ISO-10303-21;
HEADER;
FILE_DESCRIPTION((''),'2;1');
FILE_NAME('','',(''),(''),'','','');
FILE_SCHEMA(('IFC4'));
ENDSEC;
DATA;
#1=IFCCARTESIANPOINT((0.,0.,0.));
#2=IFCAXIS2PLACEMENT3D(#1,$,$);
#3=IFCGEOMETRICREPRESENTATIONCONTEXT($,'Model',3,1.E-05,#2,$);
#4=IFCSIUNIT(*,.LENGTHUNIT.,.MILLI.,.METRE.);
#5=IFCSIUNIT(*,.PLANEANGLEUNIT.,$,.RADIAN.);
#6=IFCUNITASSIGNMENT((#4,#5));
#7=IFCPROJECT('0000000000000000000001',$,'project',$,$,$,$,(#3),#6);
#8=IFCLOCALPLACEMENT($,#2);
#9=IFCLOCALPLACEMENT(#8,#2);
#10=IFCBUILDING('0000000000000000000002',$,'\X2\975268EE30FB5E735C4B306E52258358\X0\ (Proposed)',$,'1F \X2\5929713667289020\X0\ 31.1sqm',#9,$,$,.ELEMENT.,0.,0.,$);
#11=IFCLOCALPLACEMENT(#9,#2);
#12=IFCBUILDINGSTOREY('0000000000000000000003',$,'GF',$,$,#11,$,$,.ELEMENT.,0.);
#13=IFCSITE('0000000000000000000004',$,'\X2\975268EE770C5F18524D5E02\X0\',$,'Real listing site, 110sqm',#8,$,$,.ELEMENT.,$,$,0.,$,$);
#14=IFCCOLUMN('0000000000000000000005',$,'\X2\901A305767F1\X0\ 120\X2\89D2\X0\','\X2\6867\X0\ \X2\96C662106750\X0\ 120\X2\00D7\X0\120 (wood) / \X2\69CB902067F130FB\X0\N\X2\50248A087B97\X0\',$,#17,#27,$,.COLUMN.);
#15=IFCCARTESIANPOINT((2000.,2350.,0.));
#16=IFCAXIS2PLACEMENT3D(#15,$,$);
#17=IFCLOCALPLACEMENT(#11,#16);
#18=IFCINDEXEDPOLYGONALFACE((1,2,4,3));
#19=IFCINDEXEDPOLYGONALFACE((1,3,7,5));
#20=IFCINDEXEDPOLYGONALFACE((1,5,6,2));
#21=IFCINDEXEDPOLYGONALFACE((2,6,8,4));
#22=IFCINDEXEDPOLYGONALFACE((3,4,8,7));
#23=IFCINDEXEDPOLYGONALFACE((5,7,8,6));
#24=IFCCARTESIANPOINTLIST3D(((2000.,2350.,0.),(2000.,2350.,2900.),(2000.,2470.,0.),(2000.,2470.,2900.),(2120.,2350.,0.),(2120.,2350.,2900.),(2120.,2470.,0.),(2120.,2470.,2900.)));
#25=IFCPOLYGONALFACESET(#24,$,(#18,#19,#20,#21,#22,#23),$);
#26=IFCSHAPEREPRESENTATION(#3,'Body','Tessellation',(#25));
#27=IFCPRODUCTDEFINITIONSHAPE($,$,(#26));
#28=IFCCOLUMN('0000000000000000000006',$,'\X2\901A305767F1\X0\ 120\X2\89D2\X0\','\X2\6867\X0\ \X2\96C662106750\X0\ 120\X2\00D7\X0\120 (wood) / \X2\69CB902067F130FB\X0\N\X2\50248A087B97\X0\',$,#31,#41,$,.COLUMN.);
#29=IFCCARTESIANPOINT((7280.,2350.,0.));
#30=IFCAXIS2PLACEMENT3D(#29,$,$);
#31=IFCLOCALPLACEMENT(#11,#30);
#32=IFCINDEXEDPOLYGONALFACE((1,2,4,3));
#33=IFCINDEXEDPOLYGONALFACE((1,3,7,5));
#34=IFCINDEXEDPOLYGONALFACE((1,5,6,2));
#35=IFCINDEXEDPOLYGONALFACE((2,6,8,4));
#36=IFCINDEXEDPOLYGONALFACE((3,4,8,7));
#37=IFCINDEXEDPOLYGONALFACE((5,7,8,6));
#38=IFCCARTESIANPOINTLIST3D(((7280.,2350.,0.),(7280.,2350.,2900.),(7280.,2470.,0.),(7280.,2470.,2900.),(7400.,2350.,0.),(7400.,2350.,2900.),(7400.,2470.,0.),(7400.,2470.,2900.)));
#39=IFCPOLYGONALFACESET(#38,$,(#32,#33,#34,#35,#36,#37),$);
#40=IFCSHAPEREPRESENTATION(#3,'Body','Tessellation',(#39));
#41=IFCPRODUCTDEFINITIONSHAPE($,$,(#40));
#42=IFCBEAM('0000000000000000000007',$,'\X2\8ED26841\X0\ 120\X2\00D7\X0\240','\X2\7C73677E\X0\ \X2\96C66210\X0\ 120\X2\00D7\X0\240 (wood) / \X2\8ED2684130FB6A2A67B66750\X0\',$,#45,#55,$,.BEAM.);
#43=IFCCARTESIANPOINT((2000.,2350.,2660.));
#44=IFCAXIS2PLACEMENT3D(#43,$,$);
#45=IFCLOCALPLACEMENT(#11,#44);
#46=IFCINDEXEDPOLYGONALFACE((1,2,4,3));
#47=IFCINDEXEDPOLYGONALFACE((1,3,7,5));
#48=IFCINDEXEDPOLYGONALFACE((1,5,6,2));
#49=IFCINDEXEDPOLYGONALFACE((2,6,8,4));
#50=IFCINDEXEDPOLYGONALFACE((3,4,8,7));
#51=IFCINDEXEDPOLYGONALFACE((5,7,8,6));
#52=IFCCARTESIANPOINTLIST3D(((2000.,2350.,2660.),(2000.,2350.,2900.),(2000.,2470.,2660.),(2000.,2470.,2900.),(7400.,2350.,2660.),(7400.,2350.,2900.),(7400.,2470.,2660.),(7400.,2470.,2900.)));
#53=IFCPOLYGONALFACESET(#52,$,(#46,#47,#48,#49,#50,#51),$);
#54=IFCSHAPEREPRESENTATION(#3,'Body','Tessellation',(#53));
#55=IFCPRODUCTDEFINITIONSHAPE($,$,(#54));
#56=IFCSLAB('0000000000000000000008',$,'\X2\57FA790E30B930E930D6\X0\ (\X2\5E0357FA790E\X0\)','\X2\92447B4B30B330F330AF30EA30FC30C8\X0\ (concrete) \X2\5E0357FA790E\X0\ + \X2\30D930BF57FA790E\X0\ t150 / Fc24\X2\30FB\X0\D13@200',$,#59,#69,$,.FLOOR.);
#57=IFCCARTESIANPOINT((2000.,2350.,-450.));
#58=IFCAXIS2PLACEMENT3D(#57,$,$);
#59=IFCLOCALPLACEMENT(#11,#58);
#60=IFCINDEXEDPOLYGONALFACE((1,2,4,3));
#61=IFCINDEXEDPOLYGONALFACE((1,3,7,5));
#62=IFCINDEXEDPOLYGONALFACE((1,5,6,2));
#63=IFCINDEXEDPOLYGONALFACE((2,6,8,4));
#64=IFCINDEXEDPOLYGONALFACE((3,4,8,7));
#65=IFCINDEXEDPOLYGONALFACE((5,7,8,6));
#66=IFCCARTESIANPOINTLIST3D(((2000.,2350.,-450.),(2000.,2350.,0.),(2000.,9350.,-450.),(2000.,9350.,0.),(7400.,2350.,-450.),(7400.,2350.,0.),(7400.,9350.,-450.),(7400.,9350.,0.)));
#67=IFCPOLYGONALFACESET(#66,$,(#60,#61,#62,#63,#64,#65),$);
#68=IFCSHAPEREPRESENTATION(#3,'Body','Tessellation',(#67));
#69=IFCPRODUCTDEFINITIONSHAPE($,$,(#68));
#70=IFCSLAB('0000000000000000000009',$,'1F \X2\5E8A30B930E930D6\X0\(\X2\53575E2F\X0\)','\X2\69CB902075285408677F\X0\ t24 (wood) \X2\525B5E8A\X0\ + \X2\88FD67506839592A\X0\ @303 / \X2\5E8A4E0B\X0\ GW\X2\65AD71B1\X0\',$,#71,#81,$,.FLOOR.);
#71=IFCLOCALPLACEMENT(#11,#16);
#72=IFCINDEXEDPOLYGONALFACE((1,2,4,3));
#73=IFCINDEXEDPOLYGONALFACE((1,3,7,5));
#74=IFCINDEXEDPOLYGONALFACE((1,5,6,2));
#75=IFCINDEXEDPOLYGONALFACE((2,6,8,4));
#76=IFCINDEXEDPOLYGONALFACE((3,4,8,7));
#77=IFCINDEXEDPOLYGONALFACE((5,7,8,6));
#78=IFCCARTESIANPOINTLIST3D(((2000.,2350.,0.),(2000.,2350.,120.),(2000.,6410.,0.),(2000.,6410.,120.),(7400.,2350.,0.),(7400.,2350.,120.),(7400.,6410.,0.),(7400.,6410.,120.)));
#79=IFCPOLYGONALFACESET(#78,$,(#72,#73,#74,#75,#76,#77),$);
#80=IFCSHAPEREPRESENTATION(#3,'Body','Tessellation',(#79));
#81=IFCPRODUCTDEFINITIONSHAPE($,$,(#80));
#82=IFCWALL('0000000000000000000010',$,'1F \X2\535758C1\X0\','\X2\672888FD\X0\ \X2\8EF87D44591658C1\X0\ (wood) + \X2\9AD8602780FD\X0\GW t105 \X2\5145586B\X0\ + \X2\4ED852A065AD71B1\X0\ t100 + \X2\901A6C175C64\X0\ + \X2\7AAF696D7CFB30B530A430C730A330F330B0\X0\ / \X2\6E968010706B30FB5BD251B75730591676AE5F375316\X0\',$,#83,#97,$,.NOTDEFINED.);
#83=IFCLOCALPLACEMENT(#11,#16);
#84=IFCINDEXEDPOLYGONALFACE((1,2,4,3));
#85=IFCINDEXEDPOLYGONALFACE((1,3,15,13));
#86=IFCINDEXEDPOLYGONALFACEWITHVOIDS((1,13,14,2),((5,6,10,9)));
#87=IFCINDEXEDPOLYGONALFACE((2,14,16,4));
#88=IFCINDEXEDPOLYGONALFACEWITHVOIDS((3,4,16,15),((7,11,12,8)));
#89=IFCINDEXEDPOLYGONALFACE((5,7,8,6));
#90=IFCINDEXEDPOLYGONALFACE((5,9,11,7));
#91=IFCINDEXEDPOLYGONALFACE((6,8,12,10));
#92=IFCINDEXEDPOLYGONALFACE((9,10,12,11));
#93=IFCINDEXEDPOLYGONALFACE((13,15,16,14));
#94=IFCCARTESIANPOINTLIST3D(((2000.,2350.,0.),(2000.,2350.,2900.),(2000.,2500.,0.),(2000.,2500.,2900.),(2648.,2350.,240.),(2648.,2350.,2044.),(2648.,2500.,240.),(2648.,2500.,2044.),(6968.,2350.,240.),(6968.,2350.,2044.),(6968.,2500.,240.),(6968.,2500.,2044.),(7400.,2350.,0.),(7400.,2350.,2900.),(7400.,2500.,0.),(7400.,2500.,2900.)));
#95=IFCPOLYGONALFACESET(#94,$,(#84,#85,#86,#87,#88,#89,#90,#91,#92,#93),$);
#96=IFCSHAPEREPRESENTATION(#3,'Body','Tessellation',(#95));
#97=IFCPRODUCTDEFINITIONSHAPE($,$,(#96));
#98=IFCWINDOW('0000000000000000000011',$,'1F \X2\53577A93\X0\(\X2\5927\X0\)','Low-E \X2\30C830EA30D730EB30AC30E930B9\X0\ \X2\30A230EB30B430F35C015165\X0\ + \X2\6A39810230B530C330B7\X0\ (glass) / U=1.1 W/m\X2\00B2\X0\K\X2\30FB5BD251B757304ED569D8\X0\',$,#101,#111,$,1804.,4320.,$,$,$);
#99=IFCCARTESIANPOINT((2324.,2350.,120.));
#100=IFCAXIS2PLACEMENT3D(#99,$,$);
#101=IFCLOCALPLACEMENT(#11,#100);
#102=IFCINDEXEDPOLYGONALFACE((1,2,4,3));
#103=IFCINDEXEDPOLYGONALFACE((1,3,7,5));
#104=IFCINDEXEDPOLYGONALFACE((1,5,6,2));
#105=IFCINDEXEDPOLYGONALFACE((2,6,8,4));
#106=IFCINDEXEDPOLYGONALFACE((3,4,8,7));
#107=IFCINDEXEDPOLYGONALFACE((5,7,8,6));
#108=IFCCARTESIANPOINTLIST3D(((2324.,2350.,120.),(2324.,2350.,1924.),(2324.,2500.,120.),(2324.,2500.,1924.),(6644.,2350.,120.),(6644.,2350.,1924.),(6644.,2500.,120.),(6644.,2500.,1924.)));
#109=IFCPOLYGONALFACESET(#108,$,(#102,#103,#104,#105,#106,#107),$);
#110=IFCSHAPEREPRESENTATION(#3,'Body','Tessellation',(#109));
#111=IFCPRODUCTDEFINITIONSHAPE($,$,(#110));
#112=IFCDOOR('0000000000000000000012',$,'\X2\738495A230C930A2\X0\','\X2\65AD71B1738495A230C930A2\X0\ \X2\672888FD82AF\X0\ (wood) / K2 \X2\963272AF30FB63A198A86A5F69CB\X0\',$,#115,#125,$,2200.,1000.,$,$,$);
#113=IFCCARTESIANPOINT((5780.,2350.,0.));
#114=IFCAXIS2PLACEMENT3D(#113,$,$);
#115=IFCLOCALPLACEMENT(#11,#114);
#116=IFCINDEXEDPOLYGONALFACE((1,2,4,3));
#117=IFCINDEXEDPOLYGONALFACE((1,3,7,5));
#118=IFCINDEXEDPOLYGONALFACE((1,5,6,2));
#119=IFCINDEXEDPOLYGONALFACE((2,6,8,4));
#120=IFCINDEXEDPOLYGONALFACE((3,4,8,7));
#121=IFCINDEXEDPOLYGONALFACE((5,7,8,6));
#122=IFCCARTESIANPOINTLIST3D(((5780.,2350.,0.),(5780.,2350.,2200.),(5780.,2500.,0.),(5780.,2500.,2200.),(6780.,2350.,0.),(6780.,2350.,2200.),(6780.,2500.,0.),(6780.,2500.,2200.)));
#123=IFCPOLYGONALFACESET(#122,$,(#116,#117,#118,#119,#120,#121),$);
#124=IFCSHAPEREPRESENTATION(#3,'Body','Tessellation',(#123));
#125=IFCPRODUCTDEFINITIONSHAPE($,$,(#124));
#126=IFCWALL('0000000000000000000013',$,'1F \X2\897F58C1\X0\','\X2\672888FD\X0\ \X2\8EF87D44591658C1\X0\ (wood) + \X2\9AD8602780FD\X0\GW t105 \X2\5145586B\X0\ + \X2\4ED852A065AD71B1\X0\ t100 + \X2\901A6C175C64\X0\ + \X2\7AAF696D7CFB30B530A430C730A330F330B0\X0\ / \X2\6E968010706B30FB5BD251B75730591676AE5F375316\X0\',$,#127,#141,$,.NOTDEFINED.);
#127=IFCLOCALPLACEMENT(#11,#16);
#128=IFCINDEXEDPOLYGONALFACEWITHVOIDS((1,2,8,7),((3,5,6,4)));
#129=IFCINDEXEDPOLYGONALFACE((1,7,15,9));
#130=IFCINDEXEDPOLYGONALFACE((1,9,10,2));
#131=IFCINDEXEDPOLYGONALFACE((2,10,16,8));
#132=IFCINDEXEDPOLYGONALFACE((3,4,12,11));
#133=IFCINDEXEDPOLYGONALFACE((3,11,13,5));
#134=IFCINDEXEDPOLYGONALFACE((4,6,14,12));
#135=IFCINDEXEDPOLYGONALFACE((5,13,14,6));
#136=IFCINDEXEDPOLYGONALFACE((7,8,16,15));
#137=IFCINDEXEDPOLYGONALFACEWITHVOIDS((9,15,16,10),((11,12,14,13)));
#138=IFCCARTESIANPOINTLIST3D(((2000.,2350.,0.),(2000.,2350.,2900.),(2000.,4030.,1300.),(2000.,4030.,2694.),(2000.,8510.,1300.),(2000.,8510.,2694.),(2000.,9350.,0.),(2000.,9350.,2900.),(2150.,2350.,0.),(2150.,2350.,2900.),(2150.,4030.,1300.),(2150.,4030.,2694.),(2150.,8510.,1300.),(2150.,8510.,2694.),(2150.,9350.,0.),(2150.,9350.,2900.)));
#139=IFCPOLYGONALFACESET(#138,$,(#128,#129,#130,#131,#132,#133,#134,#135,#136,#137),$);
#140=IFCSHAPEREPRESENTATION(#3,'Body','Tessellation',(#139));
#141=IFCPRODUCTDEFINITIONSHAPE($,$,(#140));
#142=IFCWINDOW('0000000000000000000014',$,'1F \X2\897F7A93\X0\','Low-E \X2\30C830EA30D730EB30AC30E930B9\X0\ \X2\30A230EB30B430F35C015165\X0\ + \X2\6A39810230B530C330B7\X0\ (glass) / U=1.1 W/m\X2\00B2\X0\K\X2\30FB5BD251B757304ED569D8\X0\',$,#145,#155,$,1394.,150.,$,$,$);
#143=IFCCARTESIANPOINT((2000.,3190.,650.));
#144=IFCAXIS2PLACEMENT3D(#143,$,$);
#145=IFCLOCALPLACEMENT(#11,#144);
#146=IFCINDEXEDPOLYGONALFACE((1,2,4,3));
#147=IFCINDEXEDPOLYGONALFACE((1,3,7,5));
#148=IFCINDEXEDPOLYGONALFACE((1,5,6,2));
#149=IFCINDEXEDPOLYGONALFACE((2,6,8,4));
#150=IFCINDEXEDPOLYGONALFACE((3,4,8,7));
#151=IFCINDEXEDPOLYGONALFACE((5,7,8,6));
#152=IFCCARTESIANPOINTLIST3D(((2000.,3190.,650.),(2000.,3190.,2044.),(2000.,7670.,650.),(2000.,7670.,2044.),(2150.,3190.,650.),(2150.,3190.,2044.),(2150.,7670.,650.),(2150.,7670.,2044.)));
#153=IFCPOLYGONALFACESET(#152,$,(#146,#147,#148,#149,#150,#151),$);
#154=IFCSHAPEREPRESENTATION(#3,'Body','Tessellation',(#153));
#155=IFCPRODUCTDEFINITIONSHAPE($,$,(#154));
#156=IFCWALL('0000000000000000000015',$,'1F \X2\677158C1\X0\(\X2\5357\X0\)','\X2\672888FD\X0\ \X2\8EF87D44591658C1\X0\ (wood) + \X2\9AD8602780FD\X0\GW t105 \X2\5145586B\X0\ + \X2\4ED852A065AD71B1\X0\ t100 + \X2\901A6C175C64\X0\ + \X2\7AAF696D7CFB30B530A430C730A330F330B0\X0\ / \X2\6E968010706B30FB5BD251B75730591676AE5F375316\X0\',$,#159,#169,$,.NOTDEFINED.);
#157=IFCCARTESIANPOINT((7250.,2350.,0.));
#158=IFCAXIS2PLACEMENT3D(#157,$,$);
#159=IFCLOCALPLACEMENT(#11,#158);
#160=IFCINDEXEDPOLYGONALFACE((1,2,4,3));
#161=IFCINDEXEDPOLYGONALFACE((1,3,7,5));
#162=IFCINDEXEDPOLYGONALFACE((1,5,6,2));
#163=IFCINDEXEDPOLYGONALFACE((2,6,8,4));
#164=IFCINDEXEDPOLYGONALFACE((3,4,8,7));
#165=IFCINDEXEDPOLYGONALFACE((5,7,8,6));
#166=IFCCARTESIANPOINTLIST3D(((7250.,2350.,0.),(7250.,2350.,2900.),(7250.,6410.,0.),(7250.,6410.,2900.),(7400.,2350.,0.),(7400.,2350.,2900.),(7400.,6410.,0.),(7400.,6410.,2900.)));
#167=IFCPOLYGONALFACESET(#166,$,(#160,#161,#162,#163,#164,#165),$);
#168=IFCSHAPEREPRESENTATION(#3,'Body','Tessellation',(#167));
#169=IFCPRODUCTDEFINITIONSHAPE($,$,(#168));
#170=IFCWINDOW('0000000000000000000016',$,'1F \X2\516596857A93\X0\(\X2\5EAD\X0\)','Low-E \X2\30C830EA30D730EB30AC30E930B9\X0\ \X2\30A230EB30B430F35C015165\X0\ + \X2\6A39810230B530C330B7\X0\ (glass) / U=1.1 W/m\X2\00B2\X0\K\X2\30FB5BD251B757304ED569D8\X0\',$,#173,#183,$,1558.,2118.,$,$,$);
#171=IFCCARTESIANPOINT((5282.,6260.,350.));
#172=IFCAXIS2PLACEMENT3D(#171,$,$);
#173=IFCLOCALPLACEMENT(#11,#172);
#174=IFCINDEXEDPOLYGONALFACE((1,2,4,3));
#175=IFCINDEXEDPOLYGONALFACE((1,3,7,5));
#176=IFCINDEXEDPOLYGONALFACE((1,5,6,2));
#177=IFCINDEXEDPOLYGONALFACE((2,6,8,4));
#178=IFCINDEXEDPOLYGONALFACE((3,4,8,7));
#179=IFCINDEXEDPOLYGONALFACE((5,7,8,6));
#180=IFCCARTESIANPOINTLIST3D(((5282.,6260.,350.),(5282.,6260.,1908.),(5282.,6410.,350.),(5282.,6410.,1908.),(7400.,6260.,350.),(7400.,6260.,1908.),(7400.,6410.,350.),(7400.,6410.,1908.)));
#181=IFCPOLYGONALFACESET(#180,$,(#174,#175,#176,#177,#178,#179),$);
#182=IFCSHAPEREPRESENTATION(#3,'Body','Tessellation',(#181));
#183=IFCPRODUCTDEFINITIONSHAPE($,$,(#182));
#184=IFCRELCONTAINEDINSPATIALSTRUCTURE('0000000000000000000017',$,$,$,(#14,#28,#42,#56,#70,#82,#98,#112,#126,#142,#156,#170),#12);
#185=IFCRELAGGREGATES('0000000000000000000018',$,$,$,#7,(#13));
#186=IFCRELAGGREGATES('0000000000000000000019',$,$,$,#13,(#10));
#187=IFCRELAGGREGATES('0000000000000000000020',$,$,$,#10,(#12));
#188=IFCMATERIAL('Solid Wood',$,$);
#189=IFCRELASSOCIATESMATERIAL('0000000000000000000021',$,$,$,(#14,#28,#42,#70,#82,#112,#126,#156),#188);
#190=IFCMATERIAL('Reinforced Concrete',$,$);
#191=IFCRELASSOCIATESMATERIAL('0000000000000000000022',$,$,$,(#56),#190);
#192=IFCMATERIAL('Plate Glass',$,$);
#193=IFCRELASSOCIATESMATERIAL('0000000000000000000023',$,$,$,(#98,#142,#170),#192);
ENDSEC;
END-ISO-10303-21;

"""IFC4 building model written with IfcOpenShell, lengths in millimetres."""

from ifc_helpers import new_model, si_unit, frame, frame_2d, origin, place, context, project, spatial, rectangle, extrude, material, element, fill, save


model = new_model("IFC4")

# Units and contexts
model_context = context("Model", 3, precision=1e-05, world=origin())
ifc_project = project(units=[si_unit("LENGTHUNIT", "METRE", prefix="MILLI"), si_unit("PLANEANGLEUNIT", "RADIAN")], contexts=[model_context])

# Site, building, storey
site_placement = place(None, origin())
site = spatial("IfcSite", under=ifc_project, at=site_placement, Name="青森県弘前市", ObjectType="Real listing site, 110sqm", CompositionType="ELEMENT", RefElevation=0.0)
building_placement = place(site_placement, origin())
building = spatial("IfcBuilding", under=site, at=building_placement, Name="青森・平屋の別荘 (Proposed)", ObjectType="1F 天然木造 31.1sqm", CompositionType="ELEMENT", ElevationOfRefHeight=0.0, ElevationOfTerrain=0.0)
storey_placement = place(building_placement, origin())
storey = spatial("IfcBuildingStorey", under=building, at=storey_placement, Name="GF", CompositionType="ELEMENT", Elevation=0.0)

# Columns
ifc_material_1 = material(Name="Solid Wood")
column_1_placement = place(storey_placement, frame((2000.0, 2350.0, 0.0)))
element("IfcColumn", 1, at=column_1_placement, inside=storey, material=ifc_material_1, Name="通し柱 120角", Description="桧 集成材 120×120 (wood) / 構造柱・N値計算", PredefinedType="COLUMN", context=model_context, shape_type="SweptSolid", body=[
    extrude(rectangle(XDim=120.0, YDim=120.0, at=frame_2d((60.0, 60.0))), frame((2000.0, 2350.0, 0.0)), (0.0, 0.0, 1.0), 2900.0),
])
column_2_placement = place(storey_placement, frame((7280.0, 2350.0, 0.0)))
element("IfcColumn", 2, at=column_2_placement, inside=storey, material=ifc_material_1, Name="通し柱 120角", Description="桧 集成材 120×120 (wood) / 構造柱・N値計算", PredefinedType="COLUMN", context=model_context, shape_type="SweptSolid", body=[
    extrude(rectangle(XDim=120.0, YDim=120.0, at=frame_2d((60.0, 60.0))), frame((7280.0, 2350.0, 0.0)), (0.0, 0.0, 1.0), 2900.0),
])

# Beam
beam_1_placement = place(storey_placement, frame((2000.0, 2350.0, 2660.0)))
element("IfcBeam", 3, at=beam_1_placement, inside=storey, material=ifc_material_1, Name="軒桁 120×240", Description="米松 集成 120×240 (wood) / 軒桁・横架材", PredefinedType="BEAM", context=model_context, shape_type="SweptSolid", body=[
    extrude(rectangle(XDim=5400.0, YDim=120.0, at=frame_2d((2700.0, 60.0))), frame((2000.0, 2350.0, 2660.0)), (0.0, 0.0, 1.0), 240.0),
])

# Slabs
ifc_material_2 = material(Name="Reinforced Concrete")
slab_1_placement = place(storey_placement, frame((2000.0, 2350.0, -450.0)))
element("IfcSlab", 4, at=slab_1_placement, inside=storey, material=ifc_material_2, Name="基礎スラブ (布基礎)", Description="鉄筋コンクリート (concrete) 布基礎 + ベタ基礎 t150 / Fc24・D13@200", PredefinedType="FLOOR", context=model_context, shape_type="SweptSolid", body=[
    extrude(rectangle(XDim=5400.0, YDim=7000.0, at=frame_2d((2700.0, 3500.0))), frame((2000.0, 2350.0, -450.0)), (0.0, 0.0, 1.0), 450.0),
])
slab_2_placement = place(storey_placement, frame((2000.0, 2350.0, 0.0)))
element("IfcSlab", 5, at=slab_2_placement, inside=storey, material=ifc_material_1, Name="1F 床スラブ(南帯)", Description="構造用合板 t24 (wood) 剛床 + 製材根太 @303 / 床下 GW断熱", PredefinedType="FLOOR", context=model_context, shape_type="SweptSolid", body=[
    extrude(rectangle(XDim=5400.0, YDim=4060.0, at=frame_2d((2700.0, 2030.0))), frame((2000.0, 2350.0, 0.0)), (0.0, 0.0, 1.0), 120.0),
])

# Wall, openings, window, door
wall_1_placement = place(storey_placement, frame((2000.0, 2350.0, 0.0)))
wall_1 = element("IfcWall", 6, at=wall_1_placement, inside=storey, material=ifc_material_1, Name="1F 南壁", Description="木製 軸組外壁 (wood) + 高性能GW t105 充填 + 付加断熱 t100 + 通気層 + 窯業系サイディング / 準耐火・寒冷地外皮強化", PredefinedType="NOTDEFINED", context=model_context, shape_type="SweptSolid", body=[
    extrude(rectangle(XDim=5400.0, YDim=150.0, at=frame_2d((2700.0, 75.0))), frame((2000.0, 2350.0, 0.0)), (0.0, 0.0, 1.0), 2900.0),
])
opening_1_placement = place(storey_placement, frame((2324.0, 2350.0, 120.0)))
opening_1 = element("IfcOpeningElement", 7, at=opening_1_placement, cuts=wall_1, PredefinedType="NOTDEFINED", context=model_context, shape_type="SweptSolid", body=[
    extrude(rectangle(XDim=4320.0, YDim=150.0, at=frame_2d((2160.0, 75.0))), frame((2324.0, 2350.0, 120.0)), (0.0, 0.0, 1.0), 1804.0),
])
opening_2_placement = place(storey_placement, frame((5780.0, 2350.0, 0.0)))
opening_2 = element("IfcOpeningElement", 8, at=opening_2_placement, cuts=wall_1, PredefinedType="NOTDEFINED", context=model_context, shape_type="SweptSolid", body=[
    extrude(rectangle(XDim=1000.0, YDim=150.0, at=frame_2d((500.0, 75.0))), frame((5780.0, 2350.0, 0.0)), (0.0, 0.0, 1.0), 2200.0),
])
ifc_material_3 = material(Name="Plate Glass")
window_1_placement = place(storey_placement, frame((2324.0, 2350.0, 120.0)))
window_1 = element("IfcWindow", 9, at=window_1_placement, inside=storey, material=ifc_material_3, Name="1F 南窓(大)", Description="Low-E トリプルガラス アルゴン封入 + 樹脂サッシ (glass) / U=1.1 W/m²K・寒冷地仕様", OverallHeight=1804.0, OverallWidth=4320.0, context=model_context, shape_type="SweptSolid", body=[
    extrude(rectangle(XDim=4320.0, YDim=150.0, at=frame_2d((2160.0, 75.0))), frame((2324.0, 2350.0, 120.0)), (0.0, 0.0, 1.0), 1804.0),
])
fill(opening_1, window_1)
door_1_placement = place(storey_placement, frame((5780.0, 2350.0, 0.0)))
door_1 = element("IfcDoor", 10, at=door_1_placement, inside=storey, material=ifc_material_1, Name="玄関ドア", Description="断熱玄関ドア 木製芯 (wood) / K2 防犯・採風機構", OverallHeight=2200.0, OverallWidth=1000.0, context=model_context, shape_type="SweptSolid", body=[
    extrude(rectangle(XDim=1000.0, YDim=150.0, at=frame_2d((500.0, 75.0))), frame((5780.0, 2350.0, 0.0)), (0.0, 0.0, 1.0), 2200.0),
])
fill(opening_2, door_1)

# Walls, openings, windows
wall_2_placement = place(storey_placement, frame((2000.0, 2350.0, 0.0)))
wall_2 = element("IfcWall", 11, at=wall_2_placement, inside=storey, material=ifc_material_1, Name="1F 西壁", Description="木製 軸組外壁 (wood) + 高性能GW t105 充填 + 付加断熱 t100 + 通気層 + 窯業系サイディング / 準耐火・寒冷地外皮強化", PredefinedType="NOTDEFINED", context=model_context, shape_type="SweptSolid", body=[
    extrude(rectangle(XDim=150.0, YDim=7000.0, at=frame_2d((75.0, 3500.0))), frame((2000.0, 2350.0, 0.0)), (0.0, 0.0, 1.0), 2900.0),
])
opening_3_placement = place(storey_placement, frame((2000.0, 3190.0, 650.0)))
opening_3 = element("IfcOpeningElement", 12, at=opening_3_placement, cuts=wall_2, PredefinedType="NOTDEFINED", context=model_context, shape_type="SweptSolid", body=[
    extrude(rectangle(XDim=150.0, YDim=4480.0, at=frame_2d((75.0, 2240.0))), frame((2000.0, 3190.0, 650.0)), (0.0, 0.0, 1.0), 1394.0),
])
window_2_placement = place(storey_placement, frame((2000.0, 3190.0, 650.0)))
window_2 = element("IfcWindow", 13, at=window_2_placement, inside=storey, material=ifc_material_3, Name="1F 西窓", Description="Low-E トリプルガラス アルゴン封入 + 樹脂サッシ (glass) / U=1.1 W/m²K・寒冷地仕様", OverallHeight=1394.0, OverallWidth=150.0, context=model_context, shape_type="SweptSolid", body=[
    extrude(rectangle(XDim=150.0, YDim=4480.0, at=frame_2d((75.0, 2240.0))), frame((2000.0, 3190.0, 650.0)), (0.0, 0.0, 1.0), 1394.0),
])
fill(opening_3, window_2)
wall_3_placement = place(storey_placement, frame((7250.0, 2350.0, 0.0)))
wall_3 = element("IfcWall", 14, at=wall_3_placement, inside=storey, material=ifc_material_1, Name="1F 東壁(南)", Description="木製 軸組外壁 (wood) + 高性能GW t105 充填 + 付加断熱 t100 + 通気層 + 窯業系サイディング / 準耐火・寒冷地外皮強化", PredefinedType="NOTDEFINED", context=model_context, shape_type="SweptSolid", body=[
    extrude(rectangle(XDim=150.0, YDim=4060.0, at=frame_2d((75.0, 2030.0))), frame((7250.0, 2350.0, 0.0)), (0.0, 0.0, 1.0), 2900.0),
])
opening_4_placement = place(storey_placement, frame((5282.0, 6260.0, 350.0)))
opening_4 = element("IfcOpeningElement", 15, at=opening_4_placement, cuts=wall_3, PredefinedType="NOTDEFINED", context=model_context, shape_type="SweptSolid", body=[
    extrude(rectangle(XDim=2118.0, YDim=150.0, at=frame_2d((1059.0, 75.0))), frame((5282.0, 6260.0, 350.0)), (0.0, 0.0, 1.0), 1558.0),
])
window_3_placement = place(storey_placement, frame((5282.0, 6260.0, 350.0)))
window_3 = element("IfcWindow", 16, at=window_3_placement, inside=storey, material=ifc_material_3, Name="1F 入隅窓(庭)", Description="Low-E トリプルガラス アルゴン封入 + 樹脂サッシ (glass) / U=1.1 W/m²K・寒冷地仕様", OverallHeight=1558.0, OverallWidth=2118.0, context=model_context, shape_type="SweptSolid", body=[
    extrude(rectangle(XDim=2118.0, YDim=150.0, at=frame_2d((1059.0, 75.0))), frame((5282.0, 6260.0, 350.0)), (0.0, 0.0, 1.0), 1558.0),
])
fill(opening_4, window_3)

save(model, "model.ifc")
